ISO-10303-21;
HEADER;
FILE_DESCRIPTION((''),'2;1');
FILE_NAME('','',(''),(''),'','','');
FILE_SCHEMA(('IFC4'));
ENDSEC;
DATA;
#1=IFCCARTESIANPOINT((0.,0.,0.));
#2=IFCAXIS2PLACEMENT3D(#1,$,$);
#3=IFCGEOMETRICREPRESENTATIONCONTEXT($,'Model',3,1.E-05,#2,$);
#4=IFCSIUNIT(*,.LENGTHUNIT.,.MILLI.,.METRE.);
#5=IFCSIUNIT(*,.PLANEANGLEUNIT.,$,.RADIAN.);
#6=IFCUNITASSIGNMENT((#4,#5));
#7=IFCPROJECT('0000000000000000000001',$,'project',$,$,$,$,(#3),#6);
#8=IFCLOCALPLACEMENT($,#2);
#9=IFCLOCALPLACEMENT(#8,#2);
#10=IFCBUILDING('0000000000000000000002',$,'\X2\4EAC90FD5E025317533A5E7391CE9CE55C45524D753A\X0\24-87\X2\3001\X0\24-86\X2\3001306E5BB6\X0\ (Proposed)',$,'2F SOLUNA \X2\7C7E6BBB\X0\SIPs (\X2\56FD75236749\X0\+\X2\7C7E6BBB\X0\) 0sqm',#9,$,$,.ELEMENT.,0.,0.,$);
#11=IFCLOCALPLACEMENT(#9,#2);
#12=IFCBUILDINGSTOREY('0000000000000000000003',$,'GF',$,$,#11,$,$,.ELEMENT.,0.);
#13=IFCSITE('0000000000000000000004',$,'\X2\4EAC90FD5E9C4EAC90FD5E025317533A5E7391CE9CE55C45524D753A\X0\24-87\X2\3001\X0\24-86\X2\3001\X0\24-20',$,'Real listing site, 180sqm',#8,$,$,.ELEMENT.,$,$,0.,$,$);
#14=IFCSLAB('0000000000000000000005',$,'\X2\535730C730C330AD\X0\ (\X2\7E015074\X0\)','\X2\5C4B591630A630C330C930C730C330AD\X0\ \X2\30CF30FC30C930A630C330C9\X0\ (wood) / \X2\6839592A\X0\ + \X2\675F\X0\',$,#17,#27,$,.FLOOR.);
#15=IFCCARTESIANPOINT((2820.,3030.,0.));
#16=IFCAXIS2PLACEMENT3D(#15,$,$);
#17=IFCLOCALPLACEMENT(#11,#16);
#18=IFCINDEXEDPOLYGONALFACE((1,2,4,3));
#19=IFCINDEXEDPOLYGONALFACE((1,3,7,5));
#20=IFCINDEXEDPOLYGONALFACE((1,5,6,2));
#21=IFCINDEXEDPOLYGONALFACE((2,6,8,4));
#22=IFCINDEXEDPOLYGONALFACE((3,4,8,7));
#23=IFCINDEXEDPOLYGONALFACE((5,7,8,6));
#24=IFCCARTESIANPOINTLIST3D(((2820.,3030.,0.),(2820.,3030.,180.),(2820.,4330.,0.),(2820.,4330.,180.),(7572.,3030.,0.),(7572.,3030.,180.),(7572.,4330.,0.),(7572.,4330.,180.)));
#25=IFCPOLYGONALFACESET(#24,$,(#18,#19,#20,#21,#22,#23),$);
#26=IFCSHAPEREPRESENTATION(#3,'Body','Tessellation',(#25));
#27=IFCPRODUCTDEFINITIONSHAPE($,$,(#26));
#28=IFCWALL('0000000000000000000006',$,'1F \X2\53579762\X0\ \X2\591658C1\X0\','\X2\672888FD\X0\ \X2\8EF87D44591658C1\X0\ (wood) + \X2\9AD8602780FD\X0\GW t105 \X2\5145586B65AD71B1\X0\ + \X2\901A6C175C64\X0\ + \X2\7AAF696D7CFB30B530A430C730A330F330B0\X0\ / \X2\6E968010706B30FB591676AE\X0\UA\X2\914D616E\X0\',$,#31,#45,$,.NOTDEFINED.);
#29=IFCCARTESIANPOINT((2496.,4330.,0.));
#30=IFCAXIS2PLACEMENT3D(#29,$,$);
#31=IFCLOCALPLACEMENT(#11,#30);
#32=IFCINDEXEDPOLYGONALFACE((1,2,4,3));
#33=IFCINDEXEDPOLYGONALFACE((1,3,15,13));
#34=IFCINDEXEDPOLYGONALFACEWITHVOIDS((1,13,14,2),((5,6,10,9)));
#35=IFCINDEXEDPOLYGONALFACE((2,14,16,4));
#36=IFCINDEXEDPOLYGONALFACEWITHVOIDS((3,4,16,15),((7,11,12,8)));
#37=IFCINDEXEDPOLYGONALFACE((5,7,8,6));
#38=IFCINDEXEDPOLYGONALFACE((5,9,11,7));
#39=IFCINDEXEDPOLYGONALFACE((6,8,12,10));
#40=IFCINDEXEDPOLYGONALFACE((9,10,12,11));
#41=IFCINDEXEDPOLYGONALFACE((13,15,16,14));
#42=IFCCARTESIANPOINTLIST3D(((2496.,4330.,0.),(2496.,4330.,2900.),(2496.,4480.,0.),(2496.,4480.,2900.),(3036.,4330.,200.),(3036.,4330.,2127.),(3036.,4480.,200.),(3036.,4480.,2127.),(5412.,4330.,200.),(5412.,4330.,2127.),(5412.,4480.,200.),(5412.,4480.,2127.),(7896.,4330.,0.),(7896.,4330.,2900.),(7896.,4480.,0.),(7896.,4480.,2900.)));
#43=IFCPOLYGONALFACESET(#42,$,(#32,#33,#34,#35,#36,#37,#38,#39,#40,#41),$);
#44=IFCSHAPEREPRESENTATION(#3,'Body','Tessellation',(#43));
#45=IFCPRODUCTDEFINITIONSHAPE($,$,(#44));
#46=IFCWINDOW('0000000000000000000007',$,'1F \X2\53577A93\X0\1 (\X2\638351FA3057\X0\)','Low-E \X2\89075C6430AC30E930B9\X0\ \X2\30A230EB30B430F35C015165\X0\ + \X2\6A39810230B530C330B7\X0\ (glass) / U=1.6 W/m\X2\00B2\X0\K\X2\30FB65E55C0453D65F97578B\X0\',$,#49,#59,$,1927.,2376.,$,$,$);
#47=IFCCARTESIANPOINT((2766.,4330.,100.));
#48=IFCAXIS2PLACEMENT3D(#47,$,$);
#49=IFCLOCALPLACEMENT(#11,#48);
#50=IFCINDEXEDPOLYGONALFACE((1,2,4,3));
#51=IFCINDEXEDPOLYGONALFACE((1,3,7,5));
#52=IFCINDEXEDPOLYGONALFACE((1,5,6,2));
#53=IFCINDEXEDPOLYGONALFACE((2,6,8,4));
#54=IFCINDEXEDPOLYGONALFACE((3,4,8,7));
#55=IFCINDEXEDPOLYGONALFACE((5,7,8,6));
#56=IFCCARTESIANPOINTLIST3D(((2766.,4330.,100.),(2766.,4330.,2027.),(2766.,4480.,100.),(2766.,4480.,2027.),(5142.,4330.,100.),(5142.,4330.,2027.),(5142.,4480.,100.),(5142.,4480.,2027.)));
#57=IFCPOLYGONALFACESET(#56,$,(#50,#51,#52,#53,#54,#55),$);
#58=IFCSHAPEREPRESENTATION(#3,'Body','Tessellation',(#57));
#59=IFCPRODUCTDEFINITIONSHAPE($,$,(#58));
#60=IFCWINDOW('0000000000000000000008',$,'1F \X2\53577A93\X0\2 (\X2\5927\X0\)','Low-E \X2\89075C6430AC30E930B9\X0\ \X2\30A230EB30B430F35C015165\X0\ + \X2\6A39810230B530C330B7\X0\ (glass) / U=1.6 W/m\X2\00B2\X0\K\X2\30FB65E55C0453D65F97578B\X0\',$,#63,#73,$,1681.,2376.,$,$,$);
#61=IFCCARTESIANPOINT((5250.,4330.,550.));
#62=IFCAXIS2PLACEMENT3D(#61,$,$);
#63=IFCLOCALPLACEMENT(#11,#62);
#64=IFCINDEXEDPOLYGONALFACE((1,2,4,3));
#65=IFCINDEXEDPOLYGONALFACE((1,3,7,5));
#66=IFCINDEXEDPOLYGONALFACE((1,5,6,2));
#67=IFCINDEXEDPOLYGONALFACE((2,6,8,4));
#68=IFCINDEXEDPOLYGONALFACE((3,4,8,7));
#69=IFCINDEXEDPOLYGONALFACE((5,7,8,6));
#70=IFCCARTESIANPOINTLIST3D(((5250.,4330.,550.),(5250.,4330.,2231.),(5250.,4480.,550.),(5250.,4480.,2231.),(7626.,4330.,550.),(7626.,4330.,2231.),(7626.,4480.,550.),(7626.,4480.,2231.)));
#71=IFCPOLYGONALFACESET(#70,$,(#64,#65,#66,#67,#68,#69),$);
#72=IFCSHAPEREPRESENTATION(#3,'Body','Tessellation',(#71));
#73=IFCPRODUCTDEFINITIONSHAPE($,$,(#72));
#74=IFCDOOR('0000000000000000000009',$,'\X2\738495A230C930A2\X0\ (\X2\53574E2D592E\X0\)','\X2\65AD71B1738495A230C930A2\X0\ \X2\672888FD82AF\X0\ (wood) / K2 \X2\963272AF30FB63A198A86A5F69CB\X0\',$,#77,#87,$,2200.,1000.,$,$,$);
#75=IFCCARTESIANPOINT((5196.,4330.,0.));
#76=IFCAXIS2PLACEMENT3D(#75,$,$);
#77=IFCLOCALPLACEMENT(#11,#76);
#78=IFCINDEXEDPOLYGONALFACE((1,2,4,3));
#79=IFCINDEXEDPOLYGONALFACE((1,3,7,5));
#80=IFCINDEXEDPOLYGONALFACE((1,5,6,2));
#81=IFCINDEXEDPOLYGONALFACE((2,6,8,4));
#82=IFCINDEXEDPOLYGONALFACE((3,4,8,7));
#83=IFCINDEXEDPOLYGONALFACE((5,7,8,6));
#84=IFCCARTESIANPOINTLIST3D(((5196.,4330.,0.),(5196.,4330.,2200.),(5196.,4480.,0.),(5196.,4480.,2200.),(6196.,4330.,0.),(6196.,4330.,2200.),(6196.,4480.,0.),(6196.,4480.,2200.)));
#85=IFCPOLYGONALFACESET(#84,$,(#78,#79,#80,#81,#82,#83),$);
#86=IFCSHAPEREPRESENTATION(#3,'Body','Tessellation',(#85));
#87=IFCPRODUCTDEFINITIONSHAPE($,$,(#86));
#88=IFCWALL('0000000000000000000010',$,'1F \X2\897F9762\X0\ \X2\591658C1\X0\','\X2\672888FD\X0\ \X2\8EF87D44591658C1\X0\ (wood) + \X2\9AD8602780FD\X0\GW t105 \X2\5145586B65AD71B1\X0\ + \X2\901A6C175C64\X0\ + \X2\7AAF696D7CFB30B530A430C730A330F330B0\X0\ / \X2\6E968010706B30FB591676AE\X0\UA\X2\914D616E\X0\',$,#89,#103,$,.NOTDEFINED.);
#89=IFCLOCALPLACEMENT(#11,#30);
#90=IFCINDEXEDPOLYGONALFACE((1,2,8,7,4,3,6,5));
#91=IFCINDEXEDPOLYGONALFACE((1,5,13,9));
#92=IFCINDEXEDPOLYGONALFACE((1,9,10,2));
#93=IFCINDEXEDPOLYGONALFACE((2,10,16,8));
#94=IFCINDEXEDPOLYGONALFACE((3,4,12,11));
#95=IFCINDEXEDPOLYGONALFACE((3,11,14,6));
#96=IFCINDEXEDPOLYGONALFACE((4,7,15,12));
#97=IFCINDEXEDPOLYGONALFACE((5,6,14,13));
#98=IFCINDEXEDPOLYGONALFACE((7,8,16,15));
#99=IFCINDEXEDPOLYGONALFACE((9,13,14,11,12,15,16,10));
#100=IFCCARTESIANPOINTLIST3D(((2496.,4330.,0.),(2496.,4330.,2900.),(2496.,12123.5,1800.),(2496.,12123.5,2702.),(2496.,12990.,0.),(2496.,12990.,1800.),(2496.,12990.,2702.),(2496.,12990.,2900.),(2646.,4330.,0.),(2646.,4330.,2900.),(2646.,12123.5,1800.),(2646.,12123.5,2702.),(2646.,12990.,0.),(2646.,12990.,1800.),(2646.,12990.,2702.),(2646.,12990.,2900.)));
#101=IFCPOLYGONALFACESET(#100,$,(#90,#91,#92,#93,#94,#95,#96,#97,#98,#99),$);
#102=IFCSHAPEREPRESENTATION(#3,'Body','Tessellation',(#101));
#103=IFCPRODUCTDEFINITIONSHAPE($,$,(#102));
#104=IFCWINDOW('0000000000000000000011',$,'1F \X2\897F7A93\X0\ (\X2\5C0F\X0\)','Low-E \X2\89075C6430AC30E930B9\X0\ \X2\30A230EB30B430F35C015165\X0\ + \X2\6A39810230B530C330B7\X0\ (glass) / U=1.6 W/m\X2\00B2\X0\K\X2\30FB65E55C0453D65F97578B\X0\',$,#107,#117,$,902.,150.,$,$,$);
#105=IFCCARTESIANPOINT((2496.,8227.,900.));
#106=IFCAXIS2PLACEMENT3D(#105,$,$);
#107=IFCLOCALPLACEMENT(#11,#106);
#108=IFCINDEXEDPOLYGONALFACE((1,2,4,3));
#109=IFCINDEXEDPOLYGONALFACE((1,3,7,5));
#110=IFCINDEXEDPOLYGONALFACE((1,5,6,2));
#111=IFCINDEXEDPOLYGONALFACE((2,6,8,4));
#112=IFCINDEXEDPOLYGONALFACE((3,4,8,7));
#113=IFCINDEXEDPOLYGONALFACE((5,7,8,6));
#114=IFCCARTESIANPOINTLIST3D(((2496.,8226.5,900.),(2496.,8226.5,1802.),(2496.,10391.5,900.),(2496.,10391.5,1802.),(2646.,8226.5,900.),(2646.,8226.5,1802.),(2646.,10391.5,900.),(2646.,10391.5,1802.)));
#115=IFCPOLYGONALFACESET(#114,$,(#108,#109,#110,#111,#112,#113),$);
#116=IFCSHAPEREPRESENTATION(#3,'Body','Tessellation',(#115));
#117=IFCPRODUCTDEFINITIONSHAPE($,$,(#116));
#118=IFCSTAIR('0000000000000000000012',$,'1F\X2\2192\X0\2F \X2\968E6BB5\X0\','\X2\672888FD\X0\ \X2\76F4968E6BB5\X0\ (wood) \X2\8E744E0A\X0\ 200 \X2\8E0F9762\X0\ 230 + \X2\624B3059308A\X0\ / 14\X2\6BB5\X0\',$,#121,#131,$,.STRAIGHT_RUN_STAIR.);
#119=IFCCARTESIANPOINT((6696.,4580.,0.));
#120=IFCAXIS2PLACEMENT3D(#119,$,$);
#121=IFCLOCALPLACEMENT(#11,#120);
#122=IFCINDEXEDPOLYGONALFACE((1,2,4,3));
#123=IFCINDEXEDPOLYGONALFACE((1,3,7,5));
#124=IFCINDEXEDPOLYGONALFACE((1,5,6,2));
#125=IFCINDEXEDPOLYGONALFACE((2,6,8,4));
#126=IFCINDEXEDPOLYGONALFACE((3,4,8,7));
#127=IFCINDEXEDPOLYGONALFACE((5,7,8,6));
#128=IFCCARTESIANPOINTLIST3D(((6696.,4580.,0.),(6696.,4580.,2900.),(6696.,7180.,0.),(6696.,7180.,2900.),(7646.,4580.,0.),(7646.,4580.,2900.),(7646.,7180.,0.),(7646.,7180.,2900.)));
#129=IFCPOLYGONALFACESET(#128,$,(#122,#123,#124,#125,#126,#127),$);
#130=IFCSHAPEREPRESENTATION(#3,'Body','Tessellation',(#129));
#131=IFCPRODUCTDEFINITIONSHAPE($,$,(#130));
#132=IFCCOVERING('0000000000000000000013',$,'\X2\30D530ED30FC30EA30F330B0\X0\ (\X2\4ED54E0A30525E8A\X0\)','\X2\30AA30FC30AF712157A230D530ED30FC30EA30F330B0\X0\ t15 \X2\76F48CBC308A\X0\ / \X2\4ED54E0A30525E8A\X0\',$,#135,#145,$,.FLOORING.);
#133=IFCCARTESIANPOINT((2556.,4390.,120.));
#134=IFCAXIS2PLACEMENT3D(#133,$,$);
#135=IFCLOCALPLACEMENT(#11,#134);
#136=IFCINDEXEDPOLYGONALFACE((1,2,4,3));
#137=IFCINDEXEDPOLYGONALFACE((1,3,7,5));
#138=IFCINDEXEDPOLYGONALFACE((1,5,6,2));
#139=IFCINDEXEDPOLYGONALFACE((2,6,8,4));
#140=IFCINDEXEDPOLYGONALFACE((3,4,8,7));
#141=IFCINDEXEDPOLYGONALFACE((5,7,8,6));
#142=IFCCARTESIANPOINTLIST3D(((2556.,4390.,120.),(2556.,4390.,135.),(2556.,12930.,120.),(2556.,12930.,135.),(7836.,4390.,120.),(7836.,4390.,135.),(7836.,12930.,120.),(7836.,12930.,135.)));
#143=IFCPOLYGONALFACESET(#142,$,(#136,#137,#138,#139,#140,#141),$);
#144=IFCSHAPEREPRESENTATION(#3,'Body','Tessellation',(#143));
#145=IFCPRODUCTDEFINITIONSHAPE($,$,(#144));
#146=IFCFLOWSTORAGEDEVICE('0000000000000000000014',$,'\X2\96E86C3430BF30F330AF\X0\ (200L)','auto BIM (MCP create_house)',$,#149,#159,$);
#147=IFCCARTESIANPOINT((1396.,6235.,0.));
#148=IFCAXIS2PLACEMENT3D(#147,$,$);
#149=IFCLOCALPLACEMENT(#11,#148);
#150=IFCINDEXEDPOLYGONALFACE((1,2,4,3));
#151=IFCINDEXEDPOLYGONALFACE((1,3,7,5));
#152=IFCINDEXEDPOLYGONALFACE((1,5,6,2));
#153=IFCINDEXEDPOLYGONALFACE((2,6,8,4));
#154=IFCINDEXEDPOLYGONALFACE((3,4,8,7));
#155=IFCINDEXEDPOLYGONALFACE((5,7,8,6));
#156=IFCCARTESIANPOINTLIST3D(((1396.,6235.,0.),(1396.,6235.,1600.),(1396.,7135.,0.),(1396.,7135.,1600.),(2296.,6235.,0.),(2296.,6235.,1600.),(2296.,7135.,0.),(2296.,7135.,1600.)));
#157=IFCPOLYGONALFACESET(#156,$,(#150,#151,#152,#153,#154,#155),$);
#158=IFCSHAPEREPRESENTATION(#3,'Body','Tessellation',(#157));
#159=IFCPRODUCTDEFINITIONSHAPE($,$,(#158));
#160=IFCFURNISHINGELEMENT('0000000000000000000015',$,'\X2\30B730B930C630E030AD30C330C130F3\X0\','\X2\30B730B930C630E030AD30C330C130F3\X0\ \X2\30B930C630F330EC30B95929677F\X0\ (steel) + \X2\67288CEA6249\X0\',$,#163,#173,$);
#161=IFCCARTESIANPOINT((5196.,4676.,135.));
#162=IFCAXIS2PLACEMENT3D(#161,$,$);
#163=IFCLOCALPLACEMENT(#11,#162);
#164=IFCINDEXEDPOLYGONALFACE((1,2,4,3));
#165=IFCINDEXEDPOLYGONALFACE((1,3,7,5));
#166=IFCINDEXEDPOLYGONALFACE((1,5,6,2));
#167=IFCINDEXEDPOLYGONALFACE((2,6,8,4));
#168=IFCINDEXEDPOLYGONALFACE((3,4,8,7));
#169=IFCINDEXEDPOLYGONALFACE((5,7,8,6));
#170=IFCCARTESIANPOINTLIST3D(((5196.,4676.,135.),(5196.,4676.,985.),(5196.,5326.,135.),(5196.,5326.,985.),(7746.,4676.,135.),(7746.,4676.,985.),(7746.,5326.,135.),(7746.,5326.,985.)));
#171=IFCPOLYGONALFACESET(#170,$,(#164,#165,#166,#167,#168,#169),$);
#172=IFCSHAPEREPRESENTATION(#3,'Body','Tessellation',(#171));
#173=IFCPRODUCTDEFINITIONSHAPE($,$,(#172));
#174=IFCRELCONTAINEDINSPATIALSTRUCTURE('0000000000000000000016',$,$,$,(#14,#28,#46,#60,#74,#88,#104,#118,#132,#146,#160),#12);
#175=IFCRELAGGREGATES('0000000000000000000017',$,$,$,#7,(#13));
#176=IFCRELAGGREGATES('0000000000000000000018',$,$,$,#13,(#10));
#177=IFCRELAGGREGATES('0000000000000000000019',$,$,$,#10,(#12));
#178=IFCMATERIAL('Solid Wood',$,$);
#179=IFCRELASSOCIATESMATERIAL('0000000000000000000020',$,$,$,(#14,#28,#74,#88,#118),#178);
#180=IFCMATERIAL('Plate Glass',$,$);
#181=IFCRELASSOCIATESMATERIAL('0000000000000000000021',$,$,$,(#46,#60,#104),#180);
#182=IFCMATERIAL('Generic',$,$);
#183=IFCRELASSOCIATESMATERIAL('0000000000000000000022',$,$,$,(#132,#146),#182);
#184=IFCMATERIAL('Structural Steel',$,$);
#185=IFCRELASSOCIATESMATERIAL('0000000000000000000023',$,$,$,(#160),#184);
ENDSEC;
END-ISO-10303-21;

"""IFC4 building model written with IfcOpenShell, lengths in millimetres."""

from ifc_helpers import new_model, si_unit, frame, frame_2d, origin, place, context, project, spatial, rectangle, extrude, material, element, fill, save


model = new_model("IFC4")

# Units and contexts
model_context = context("Model", 3, precision=1e-05, world=origin())
ifc_project = project(units=[si_unit("LENGTHUNIT", "METRE", prefix="MILLI"), si_unit("PLANEANGLEUNIT", "RADIAN")], contexts=[model_context])

# Site, building, storey
site_placement = place(None, origin())
site = spatial("IfcSite", under=ifc_project, at=site_placement, Name="京都府京都市北区平野鳥居前町24-87、24-86、24-20", ObjectType="Real listing site, 180sqm", CompositionType="ELEMENT", RefElevation=0.0)
building_placement = place(site_placement, origin())
building = spatial("IfcBuilding", under=site, at=building_placement, Name="京都市北区平野鳥居前町24-87、24-86、の家 (Proposed)", ObjectType="2F SOLUNA 籾殻SIPs (国産杉+籾殻) 0sqm", CompositionType="ELEMENT", ElevationOfRefHeight=0.0, ElevationOfTerrain=0.0)
storey_placement = place(building_placement, origin())
storey = spatial("IfcBuildingStorey", under=building, at=storey_placement, Name="GF", CompositionType="ELEMENT", Elevation=0.0)

# Slab
ifc_material_1 = material(Name="Solid Wood")
slab_1_placement = place(storey_placement, frame((2820.0, 3030.0, 0.0)))
element("IfcSlab", 1, at=slab_1_placement, inside=storey, material=ifc_material_1, Name="南デッキ (縁側)", Description="屋外ウッドデッキ ハードウッド (wood) / 根太 + 束", PredefinedType="FLOOR", context=model_context, shape_type="SweptSolid", body=[
    extrude(rectangle(XDim=4752.0, YDim=1300.0, at=frame_2d((2376.0, 650.0))), frame((2820.0, 3030.0, 0.0)), (0.0, 0.0, 1.0), 180.0),
])

# Wall, openings, windows, door
wall_1_placement = place(storey_placement, frame((2496.0, 4330.0, 0.0)))
wall_1 = element("IfcWall", 2, at=wall_1_placement, inside=storey, material=ifc_material_1, Name="1F 南面 外壁", Description="木製 軸組外壁 (wood) + 高性能GW t105 充填断熱 + 通気層 + 窯業系サイディング / 準耐火・外皮UA配慮", PredefinedType="NOTDEFINED", context=model_context, shape_type="SweptSolid", body=[
    extrude(rectangle(XDim=5400.0, YDim=150.0, at=frame_2d((2700.0, 75.0))), frame((2496.0, 4330.0, 0.0)), (0.0, 0.0, 1.0), 2900.0),
])
opening_1_placement = place(storey_placement, frame((2766.0, 4330.0, 100.0)))
opening_1 = element("IfcOpeningElement", 3, at=opening_1_placement, cuts=wall_1, PredefinedType="NOTDEFINED", context=model_context, shape_type="SweptSolid", body=[
    extrude(rectangle(XDim=2376.0, YDim=150.0, at=frame_2d((1188.0, 75.0))), frame((2766.0, 4330.0, 100.0)), (0.0, 0.0, 1.0), 1927.0),
])
opening_2_placement = place(storey_placement, frame((5250.0, 4330.0, 550.0)))
opening_2 = element("IfcOpeningElement", 4, at=opening_2_placement, cuts=wall_1, PredefinedType="NOTDEFINED", context=model_context, shape_type="SweptSolid", body=[
    extrude(rectangle(XDim=2376.0, YDim=150.0, at=frame_2d((1188.0, 75.0))), frame((5250.0, 4330.0, 550.0)), (0.0, 0.0, 1.0), 1681.0),
])
opening_3_placement = place(storey_placement, frame((5196.0, 4330.0, 0.0)))
opening_3 = element("IfcOpeningElement", 5, at=opening_3_placement, cuts=wall_1, PredefinedType="NOTDEFINED", context=model_context, shape_type="SweptSolid", body=[
    extrude(rectangle(XDim=1000.0, YDim=150.0, at=frame_2d((500.0, 75.0))), frame((5196.0, 4330.0, 0.0)), (0.0, 0.0, 1.0), 2200.0),
])
ifc_material_2 = material(Name="Plate Glass")
window_1_placement = place(storey_placement, frame((2766.0, 4330.0, 100.0)))
window_1 = element("IfcWindow", 6, at=window_1_placement, inside=storey, material=ifc_material_2, Name="1F 南窓1 (掃出し)", Description="Low-E 複層ガラス アルゴン封入 + 樹脂サッシ (glass) / U=1.6 W/m²K・日射取得型", OverallHeight=1927.0, OverallWidth=2376.0, context=model_context, shape_type="SweptSolid", body=[
    extrude(rectangle(XDim=2376.0, YDim=150.0, at=frame_2d((1188.0, 75.0))), frame((2766.0, 4330.0, 100.0)), (0.0, 0.0, 1.0), 1927.0),
])
fill(opening_1, window_1)
window_2_placement = place(storey_placement, frame((5250.0, 4330.0, 550.0)))
window_2 = element("IfcWindow", 7, at=window_2_placement, inside=storey, material=ifc_material_2, Name="1F 南窓2 (大)", Description="Low-E 複層ガラス アルゴン封入 + 樹脂サッシ (glass) / U=1.6 W/m²K・日射取得型", OverallHeight=1681.0, OverallWidth=2376.0, context=model_context, shape_type="SweptSolid", body=[
    extrude(rectangle(XDim=2376.0, YDim=150.0, at=frame_2d((1188.0, 75.0))), frame((5250.0, 4330.0, 550.0)), (0.0, 0.0, 1.0), 1681.0),
])
fill(opening_2, window_2)
door_placement = place(storey_placement, frame((5196.0, 4330.0, 0.0)))
door = element("IfcDoor", 8, at=door_placement, inside=storey, material=ifc_material_1, Name="玄関ドア (南中央)", Description="断熱玄関ドア 木製芯 (wood) / K2 防犯・採風機構", OverallHeight=2200.0, OverallWidth=1000.0, context=model_context, shape_type="SweptSolid", body=[
    extrude(rectangle(XDim=1000.0, YDim=150.0, at=frame_2d((500.0, 75.0))), frame((5196.0, 4330.0, 0.0)), (0.0, 0.0, 1.0), 2200.0),
])
fill(opening_3, door)

# Wall, opening, window
wall_2_placement = place(storey_placement, frame((2496.0, 4330.0, 0.0)))
wall_2 = element("IfcWall", 9, at=wall_2_placement, inside=storey, material=ifc_material_1, Name="1F 西面 外壁", Description="木製 軸組外壁 (wood) + 高性能GW t105 充填断熱 + 通気層 + 窯業系サイディング / 準耐火・外皮UA配慮", PredefinedType="NOTDEFINED", context=model_context, shape_type="SweptSolid", body=[
    extrude(rectangle(XDim=150.0, YDim=8660.0, at=frame_2d((75.0, 4330.0))), frame((2496.0, 4330.0, 0.0)), (0.0, 0.0, 1.0), 2900.0),
])
opening_4_placement = place(storey_placement, frame((2496.0, 8227.0, 900.0)))
opening_4 = element("IfcOpeningElement", 10, at=opening_4_placement, cuts=wall_2, PredefinedType="NOTDEFINED", context=model_context, shape_type="SweptSolid", body=[
    extrude(rectangle(XDim=150.0, YDim=2165.0, at=frame_2d((75.0, 1082.0))), frame((2496.0, 8227.0, 900.0)), (0.0, 0.0, 1.0), 902.0),
])
window_3_placement = place(storey_placement, frame((2496.0, 8227.0, 900.0)))
window_3 = element("IfcWindow", 11, at=window_3_placement, inside=storey, material=ifc_material_2, Name="1F 西窓 (小)", Description="Low-E 複層ガラス アルゴン封入 + 樹脂サッシ (glass) / U=1.6 W/m²K・日射取得型", OverallHeight=902.0, OverallWidth=150.0, context=model_context, shape_type="SweptSolid", body=[
    extrude(rectangle(XDim=150.0, YDim=2165.0, at=frame_2d((75.0, 1082.0))), frame((2496.0, 8227.0, 900.0)), (0.0, 0.0, 1.0), 902.0),
])
fill(opening_4, window_3)

# Stair
stair_placement = place(storey_placement, frame((6696.0, 4580.0, 0.0)))
element("IfcStair", 12, at=stair_placement, inside=storey, material=ifc_material_1, Name="1F→2F 階段", Description="木製 直階段 (wood) 蹴上 200 踏面 230 + 手すり / 14段", PredefinedType="STRAIGHT_RUN_STAIR", context=model_context, shape_type="SweptSolid", body=[
    extrude(rectangle(XDim=950.0, YDim=2600.0, at=frame_2d((475.0, 1300.0))), frame((6696.0, 4580.0, 0.0)), (0.0, 0.0, 1.0), 2900.0),
])

# Covering
ifc_material_3 = material(Name="Generic")
covering_placement = place(storey_placement, frame((2556.0, 4390.0, 120.0)))
element("IfcCovering", 13, at=covering_placement, inside=storey, material=ifc_material_3, Name="フローリング (仕上げ床)", Description="オーク無垢フローリング t15 直貼り / 仕上げ床", PredefinedType="FLOORING", context=model_context, shape_type="SweptSolid", body=[
    extrude(rectangle(XDim=5280.0, YDim=8540.0, at=frame_2d((2640.0, 4270.0))), frame((2556.0, 4390.0, 120.0)), (0.0, 0.0, 1.0), 15.0),
])

# Flow storage device
flow_storage_device_placement = place(storey_placement, frame((1396.0, 6235.0, 0.0)))
element("IfcFlowStorageDevice", 14, at=flow_storage_device_placement, inside=storey, material=ifc_material_3, Name="雨水タンク (200L)", Description="auto BIM (MCP create_house)", context=model_context, shape_type="SweptSolid", body=[
    extrude(rectangle(XDim=900.0, YDim=900.0, at=frame_2d((450.0, 450.0))), frame((1396.0, 6235.0, 0.0)), (0.0, 0.0, 1.0), 1600.0),
])

# Furnishing element
ifc_material_4 = material(Name="Structural Steel")
furnishing_placement = place(storey_placement, frame((5196.0, 4676.0, 135.0)))
element("IfcFurnishingElement", 15, at=furnishing_placement, inside=storey, material=ifc_material_4, Name="システムキッチン", Description="システムキッチン ステンレス天板 (steel) + 木質扉", context=model_context, shape_type="SweptSolid", body=[
    extrude(rectangle(XDim=2550.0, YDim=650.0, at=frame_2d((1275.0, 325.0))), frame((5196.0, 4676.0, 135.0)), (0.0, 0.0, 1.0), 850.0),
])

save(model, "model.ifc")
